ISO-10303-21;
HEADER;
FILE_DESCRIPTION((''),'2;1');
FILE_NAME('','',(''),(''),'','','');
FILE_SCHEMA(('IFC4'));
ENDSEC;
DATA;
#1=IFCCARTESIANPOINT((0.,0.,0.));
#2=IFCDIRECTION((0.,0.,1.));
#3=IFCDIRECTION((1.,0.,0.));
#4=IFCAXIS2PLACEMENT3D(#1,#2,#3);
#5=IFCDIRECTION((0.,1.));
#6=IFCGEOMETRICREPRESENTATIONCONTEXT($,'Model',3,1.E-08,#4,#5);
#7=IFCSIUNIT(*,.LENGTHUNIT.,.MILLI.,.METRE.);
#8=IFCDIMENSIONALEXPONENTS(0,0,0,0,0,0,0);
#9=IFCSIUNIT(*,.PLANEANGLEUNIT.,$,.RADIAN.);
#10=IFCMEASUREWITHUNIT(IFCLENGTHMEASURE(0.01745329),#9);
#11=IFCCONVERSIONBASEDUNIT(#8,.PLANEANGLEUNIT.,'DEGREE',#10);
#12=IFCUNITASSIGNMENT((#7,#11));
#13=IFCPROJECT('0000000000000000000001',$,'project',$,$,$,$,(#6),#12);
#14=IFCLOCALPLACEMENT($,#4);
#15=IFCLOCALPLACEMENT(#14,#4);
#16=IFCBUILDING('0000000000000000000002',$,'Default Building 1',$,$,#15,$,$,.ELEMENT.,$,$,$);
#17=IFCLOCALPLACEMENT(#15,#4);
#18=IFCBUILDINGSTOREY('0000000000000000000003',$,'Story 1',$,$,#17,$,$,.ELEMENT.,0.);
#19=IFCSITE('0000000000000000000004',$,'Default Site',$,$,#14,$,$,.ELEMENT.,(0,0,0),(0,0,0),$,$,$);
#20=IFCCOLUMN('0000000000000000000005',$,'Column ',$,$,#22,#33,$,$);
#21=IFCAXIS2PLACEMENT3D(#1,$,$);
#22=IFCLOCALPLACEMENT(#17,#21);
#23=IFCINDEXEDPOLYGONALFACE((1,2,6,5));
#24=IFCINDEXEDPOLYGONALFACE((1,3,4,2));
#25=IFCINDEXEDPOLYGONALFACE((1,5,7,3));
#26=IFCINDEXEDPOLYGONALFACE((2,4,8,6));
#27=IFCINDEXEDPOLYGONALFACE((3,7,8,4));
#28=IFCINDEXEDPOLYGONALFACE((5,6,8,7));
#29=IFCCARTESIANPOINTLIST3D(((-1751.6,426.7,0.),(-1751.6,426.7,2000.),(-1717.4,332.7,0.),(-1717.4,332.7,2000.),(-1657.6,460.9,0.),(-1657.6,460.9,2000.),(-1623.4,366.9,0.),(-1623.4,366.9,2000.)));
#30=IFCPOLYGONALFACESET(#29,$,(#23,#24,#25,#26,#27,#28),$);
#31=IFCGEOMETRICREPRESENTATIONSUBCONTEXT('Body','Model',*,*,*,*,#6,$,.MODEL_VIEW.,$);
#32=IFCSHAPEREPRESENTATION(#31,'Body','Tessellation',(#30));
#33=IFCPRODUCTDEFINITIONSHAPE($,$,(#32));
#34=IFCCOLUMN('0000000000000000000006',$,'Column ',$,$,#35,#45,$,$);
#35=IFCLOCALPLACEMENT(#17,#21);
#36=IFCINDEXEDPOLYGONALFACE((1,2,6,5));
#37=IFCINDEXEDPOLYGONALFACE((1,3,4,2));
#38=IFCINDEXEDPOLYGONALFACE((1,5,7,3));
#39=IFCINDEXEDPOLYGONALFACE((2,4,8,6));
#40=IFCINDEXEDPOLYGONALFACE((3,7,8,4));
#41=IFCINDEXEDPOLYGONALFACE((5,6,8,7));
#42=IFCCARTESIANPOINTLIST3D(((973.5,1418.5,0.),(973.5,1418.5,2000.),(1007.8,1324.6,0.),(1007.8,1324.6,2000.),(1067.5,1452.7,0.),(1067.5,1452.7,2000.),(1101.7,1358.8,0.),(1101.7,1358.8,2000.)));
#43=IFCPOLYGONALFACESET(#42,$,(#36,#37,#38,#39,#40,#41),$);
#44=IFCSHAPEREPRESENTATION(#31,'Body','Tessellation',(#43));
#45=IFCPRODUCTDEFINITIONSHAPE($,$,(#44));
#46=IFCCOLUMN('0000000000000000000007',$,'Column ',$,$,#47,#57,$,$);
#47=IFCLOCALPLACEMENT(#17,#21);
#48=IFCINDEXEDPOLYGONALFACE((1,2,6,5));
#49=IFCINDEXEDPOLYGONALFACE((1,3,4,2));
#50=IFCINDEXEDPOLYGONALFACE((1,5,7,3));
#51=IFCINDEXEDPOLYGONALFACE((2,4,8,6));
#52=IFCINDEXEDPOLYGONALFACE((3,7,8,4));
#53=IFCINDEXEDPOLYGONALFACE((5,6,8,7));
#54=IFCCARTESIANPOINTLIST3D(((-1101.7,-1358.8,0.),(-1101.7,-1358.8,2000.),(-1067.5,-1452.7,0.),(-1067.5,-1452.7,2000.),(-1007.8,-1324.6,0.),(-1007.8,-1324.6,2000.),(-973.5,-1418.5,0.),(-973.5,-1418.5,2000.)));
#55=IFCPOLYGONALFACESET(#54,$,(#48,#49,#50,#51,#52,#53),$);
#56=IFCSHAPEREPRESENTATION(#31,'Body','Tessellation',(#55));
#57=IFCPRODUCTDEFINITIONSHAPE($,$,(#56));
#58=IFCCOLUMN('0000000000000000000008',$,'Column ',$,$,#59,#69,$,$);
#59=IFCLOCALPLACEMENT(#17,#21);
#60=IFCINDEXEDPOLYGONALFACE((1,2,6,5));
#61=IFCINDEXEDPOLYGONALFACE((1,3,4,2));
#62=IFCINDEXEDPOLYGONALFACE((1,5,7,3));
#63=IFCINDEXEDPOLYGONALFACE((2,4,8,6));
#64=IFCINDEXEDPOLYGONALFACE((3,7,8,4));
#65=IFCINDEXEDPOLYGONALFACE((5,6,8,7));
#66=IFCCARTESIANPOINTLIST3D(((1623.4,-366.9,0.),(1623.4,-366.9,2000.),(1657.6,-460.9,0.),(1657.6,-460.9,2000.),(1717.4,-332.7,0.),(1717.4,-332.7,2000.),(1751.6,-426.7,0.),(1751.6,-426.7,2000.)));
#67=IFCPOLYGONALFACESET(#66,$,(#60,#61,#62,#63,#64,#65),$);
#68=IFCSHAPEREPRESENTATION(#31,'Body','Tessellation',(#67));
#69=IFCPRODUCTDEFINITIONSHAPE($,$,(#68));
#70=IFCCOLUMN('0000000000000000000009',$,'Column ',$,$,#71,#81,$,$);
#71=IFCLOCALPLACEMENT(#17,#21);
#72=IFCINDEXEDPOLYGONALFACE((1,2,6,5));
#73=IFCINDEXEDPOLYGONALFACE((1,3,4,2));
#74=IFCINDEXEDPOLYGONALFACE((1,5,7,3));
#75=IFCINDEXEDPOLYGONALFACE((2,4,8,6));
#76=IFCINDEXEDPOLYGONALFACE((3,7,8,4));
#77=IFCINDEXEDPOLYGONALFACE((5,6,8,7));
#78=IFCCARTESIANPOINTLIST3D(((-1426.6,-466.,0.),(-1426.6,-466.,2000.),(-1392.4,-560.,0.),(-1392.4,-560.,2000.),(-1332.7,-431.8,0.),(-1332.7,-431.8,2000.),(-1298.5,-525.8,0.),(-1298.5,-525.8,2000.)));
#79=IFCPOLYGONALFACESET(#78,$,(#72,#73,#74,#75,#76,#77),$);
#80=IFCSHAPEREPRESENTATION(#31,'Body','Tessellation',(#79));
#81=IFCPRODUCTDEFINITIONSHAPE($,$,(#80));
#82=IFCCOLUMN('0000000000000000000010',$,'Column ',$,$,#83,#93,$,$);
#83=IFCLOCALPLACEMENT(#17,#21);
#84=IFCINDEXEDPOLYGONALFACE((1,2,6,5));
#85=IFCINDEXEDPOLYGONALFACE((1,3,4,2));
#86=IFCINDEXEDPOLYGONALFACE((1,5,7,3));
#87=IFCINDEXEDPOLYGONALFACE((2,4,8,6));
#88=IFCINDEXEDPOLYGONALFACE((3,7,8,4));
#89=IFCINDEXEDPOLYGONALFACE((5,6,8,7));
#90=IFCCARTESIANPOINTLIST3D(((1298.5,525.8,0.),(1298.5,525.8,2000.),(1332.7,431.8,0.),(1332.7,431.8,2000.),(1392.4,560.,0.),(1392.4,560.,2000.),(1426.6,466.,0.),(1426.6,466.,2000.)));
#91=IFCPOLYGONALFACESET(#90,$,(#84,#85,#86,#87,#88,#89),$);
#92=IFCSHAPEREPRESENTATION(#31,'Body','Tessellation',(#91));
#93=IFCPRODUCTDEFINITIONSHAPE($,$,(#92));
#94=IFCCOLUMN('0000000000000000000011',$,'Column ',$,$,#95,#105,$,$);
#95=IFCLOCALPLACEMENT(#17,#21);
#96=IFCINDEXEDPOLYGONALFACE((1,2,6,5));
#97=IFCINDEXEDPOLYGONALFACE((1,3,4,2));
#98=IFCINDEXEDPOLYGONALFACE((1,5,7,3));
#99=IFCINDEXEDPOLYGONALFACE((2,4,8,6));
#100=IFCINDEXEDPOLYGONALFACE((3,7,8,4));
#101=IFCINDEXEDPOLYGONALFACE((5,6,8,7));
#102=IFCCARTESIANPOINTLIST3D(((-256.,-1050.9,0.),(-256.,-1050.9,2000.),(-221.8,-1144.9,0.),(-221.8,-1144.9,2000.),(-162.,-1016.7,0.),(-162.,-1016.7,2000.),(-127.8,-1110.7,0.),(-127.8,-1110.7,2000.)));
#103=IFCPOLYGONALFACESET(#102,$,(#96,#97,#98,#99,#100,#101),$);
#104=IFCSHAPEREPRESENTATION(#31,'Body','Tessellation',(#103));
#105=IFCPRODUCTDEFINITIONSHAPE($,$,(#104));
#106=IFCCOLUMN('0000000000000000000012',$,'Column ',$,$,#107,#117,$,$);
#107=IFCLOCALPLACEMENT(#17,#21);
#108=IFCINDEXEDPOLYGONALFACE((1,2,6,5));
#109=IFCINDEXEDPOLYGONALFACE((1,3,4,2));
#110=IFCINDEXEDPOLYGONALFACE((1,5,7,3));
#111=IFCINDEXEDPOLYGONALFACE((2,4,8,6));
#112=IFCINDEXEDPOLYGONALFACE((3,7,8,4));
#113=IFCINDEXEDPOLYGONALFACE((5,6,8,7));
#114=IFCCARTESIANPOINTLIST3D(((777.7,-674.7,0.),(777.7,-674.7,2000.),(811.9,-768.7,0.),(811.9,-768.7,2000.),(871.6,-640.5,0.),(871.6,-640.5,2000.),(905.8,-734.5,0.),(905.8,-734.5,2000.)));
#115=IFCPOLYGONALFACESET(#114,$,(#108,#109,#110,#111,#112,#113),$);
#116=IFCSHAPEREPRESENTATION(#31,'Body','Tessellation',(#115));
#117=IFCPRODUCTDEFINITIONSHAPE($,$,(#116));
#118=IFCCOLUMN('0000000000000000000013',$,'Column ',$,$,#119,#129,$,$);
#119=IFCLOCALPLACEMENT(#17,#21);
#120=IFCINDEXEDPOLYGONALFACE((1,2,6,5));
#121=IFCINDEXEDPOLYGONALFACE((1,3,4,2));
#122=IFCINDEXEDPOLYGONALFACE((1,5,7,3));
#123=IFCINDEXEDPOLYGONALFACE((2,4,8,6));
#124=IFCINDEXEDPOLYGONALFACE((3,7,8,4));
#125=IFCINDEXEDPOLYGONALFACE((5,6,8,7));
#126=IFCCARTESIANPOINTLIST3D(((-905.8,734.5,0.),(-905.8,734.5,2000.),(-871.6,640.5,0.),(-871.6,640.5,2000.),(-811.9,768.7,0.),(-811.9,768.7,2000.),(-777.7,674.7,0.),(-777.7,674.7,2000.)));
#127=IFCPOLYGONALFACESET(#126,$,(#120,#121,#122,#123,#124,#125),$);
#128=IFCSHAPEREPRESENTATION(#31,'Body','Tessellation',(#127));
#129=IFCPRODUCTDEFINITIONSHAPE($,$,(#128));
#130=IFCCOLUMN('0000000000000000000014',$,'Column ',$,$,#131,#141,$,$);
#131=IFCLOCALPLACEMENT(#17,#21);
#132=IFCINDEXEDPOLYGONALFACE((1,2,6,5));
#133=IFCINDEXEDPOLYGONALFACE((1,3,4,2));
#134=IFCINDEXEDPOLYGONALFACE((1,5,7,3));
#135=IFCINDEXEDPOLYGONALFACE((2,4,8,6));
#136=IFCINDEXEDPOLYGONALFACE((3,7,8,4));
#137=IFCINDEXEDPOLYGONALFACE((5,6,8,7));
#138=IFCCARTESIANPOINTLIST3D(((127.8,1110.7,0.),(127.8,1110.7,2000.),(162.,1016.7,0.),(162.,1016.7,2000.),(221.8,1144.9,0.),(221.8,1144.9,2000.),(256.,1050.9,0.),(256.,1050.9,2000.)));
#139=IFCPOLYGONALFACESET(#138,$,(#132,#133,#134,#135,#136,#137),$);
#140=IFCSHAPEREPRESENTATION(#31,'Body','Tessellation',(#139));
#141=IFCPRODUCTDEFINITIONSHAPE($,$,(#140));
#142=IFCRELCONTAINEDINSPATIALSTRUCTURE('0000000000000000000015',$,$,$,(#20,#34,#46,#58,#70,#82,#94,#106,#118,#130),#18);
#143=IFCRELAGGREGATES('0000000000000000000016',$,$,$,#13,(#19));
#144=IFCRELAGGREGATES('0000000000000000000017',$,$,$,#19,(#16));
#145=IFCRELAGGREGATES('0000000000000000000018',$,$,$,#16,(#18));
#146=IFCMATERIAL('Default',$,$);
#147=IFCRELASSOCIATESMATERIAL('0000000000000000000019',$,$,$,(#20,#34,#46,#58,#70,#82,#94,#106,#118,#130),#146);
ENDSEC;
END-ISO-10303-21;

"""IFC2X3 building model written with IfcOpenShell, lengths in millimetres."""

from ifc_helpers import new_model, entity, si_unit, converted_unit, direction, frame, origin_with_axes, place, context, subcontext, project, spatial, polyline, outline, extrude, material, element, save


model = new_model("IFC2X3")

# Units and contexts
model_context = context("Model", 3, precision=1e-08, world=origin_with_axes(), true_north=direction((0.0, 1.0)))
body_context = subcontext(model_context, "Body", "Model", "MODEL_VIEW")
ifc_project = project(units=[si_unit("LENGTHUNIT", "METRE", prefix="MILLI"), converted_unit("PLANEANGLEUNIT", "DEGREE", entity("IfcLengthMeasure", 0.01745329), si_unit("PLANEANGLEUNIT", "RADIAN"), dimensions=[0, 0, 0, 0, 0, 0, 0])], contexts=[model_context])

# Site, building, storey
site_placement = place(None, origin_with_axes())
site = spatial("IfcSite", under=ifc_project, at=site_placement, Name="Default Site", CompositionType="ELEMENT", RefLatitude=(0, 0, 0), RefLongitude=(0, 0, 0))
building_placement = place(site_placement, origin_with_axes())
building = spatial("IfcBuilding", under=site, at=building_placement, Name="Default Building 1", CompositionType="ELEMENT")
storey_placement = place(building_placement, origin_with_axes())
storey = spatial("IfcBuildingStorey", under=building, at=storey_placement, Name="Story 1", CompositionType="ELEMENT", Elevation=0.0)

# Columns
ifc_material = material(Name="Default")
for number, where, z_axis, x_axis, name in (
    (1, (-1687.5, 396.8, 0.0), (0.0, 0.0, 1.0), (0.939693, 0.34202, 0.0), "Column "),
    (2, (1037.6, 1388.6, 0.0), (0.0, 0.0, 1.0), (0.939693, 0.34202, 0.0), "Column "),
    (3, (-1037.6, -1388.6, 0.0), (0.0, 0.0, 1.0), (0.939693, 0.34202, 0.0), "Column "),
    (4, (1687.5, -396.8, 0.0), (0.0, 0.0, 1.0), (0.939693, 0.34202, 0.0), "Column "),
    (5, (-1362.6, -495.9, 0.0), (0.0, 0.0, 1.0), (0.939693, 0.34202, 0.0), "Column "),
    (6, (1362.6, 495.9, 0.0), (0.0, 0.0, 1.0), (0.939693, 0.34202, 0.0), "Column "),
    (7, (-191.9, -1080.8, 0.0), (0.0, 0.0, 1.0), (0.939693, 0.34202, 0.0), "Column "),
    (8, (841.8, -704.6, 0.0), (0.0, 0.0, 1.0), (0.939693, 0.34202, 0.0), "Column "),
    (9, (-841.8, 704.6, 0.0), (0.0, 0.0, 1.0), (-0.939693, -0.34202, 0.0), "Column "),
    (10, (191.9, 1080.8, 0.0), (0.0, 0.0, 1.0), (-0.939693, -0.34202, 0.0), "Column "),
):
    element("IfcColumn", number, at=place(storey_placement, frame(where, z_axis=z_axis, x_axis=x_axis)), inside=storey, material=ifc_material, Name=name, context=body_context, shape_type="SweptSolid", body=[
        extrude(outline(polyline([(-50.0, -50.0), (50.0, -50.0), (50.0, 50.0), (-50.0, 50.0)])), origin_with_axes(), (0.0, 0.0, 1.0), 2000.0),
    ])

save(model, "model.ifc")
